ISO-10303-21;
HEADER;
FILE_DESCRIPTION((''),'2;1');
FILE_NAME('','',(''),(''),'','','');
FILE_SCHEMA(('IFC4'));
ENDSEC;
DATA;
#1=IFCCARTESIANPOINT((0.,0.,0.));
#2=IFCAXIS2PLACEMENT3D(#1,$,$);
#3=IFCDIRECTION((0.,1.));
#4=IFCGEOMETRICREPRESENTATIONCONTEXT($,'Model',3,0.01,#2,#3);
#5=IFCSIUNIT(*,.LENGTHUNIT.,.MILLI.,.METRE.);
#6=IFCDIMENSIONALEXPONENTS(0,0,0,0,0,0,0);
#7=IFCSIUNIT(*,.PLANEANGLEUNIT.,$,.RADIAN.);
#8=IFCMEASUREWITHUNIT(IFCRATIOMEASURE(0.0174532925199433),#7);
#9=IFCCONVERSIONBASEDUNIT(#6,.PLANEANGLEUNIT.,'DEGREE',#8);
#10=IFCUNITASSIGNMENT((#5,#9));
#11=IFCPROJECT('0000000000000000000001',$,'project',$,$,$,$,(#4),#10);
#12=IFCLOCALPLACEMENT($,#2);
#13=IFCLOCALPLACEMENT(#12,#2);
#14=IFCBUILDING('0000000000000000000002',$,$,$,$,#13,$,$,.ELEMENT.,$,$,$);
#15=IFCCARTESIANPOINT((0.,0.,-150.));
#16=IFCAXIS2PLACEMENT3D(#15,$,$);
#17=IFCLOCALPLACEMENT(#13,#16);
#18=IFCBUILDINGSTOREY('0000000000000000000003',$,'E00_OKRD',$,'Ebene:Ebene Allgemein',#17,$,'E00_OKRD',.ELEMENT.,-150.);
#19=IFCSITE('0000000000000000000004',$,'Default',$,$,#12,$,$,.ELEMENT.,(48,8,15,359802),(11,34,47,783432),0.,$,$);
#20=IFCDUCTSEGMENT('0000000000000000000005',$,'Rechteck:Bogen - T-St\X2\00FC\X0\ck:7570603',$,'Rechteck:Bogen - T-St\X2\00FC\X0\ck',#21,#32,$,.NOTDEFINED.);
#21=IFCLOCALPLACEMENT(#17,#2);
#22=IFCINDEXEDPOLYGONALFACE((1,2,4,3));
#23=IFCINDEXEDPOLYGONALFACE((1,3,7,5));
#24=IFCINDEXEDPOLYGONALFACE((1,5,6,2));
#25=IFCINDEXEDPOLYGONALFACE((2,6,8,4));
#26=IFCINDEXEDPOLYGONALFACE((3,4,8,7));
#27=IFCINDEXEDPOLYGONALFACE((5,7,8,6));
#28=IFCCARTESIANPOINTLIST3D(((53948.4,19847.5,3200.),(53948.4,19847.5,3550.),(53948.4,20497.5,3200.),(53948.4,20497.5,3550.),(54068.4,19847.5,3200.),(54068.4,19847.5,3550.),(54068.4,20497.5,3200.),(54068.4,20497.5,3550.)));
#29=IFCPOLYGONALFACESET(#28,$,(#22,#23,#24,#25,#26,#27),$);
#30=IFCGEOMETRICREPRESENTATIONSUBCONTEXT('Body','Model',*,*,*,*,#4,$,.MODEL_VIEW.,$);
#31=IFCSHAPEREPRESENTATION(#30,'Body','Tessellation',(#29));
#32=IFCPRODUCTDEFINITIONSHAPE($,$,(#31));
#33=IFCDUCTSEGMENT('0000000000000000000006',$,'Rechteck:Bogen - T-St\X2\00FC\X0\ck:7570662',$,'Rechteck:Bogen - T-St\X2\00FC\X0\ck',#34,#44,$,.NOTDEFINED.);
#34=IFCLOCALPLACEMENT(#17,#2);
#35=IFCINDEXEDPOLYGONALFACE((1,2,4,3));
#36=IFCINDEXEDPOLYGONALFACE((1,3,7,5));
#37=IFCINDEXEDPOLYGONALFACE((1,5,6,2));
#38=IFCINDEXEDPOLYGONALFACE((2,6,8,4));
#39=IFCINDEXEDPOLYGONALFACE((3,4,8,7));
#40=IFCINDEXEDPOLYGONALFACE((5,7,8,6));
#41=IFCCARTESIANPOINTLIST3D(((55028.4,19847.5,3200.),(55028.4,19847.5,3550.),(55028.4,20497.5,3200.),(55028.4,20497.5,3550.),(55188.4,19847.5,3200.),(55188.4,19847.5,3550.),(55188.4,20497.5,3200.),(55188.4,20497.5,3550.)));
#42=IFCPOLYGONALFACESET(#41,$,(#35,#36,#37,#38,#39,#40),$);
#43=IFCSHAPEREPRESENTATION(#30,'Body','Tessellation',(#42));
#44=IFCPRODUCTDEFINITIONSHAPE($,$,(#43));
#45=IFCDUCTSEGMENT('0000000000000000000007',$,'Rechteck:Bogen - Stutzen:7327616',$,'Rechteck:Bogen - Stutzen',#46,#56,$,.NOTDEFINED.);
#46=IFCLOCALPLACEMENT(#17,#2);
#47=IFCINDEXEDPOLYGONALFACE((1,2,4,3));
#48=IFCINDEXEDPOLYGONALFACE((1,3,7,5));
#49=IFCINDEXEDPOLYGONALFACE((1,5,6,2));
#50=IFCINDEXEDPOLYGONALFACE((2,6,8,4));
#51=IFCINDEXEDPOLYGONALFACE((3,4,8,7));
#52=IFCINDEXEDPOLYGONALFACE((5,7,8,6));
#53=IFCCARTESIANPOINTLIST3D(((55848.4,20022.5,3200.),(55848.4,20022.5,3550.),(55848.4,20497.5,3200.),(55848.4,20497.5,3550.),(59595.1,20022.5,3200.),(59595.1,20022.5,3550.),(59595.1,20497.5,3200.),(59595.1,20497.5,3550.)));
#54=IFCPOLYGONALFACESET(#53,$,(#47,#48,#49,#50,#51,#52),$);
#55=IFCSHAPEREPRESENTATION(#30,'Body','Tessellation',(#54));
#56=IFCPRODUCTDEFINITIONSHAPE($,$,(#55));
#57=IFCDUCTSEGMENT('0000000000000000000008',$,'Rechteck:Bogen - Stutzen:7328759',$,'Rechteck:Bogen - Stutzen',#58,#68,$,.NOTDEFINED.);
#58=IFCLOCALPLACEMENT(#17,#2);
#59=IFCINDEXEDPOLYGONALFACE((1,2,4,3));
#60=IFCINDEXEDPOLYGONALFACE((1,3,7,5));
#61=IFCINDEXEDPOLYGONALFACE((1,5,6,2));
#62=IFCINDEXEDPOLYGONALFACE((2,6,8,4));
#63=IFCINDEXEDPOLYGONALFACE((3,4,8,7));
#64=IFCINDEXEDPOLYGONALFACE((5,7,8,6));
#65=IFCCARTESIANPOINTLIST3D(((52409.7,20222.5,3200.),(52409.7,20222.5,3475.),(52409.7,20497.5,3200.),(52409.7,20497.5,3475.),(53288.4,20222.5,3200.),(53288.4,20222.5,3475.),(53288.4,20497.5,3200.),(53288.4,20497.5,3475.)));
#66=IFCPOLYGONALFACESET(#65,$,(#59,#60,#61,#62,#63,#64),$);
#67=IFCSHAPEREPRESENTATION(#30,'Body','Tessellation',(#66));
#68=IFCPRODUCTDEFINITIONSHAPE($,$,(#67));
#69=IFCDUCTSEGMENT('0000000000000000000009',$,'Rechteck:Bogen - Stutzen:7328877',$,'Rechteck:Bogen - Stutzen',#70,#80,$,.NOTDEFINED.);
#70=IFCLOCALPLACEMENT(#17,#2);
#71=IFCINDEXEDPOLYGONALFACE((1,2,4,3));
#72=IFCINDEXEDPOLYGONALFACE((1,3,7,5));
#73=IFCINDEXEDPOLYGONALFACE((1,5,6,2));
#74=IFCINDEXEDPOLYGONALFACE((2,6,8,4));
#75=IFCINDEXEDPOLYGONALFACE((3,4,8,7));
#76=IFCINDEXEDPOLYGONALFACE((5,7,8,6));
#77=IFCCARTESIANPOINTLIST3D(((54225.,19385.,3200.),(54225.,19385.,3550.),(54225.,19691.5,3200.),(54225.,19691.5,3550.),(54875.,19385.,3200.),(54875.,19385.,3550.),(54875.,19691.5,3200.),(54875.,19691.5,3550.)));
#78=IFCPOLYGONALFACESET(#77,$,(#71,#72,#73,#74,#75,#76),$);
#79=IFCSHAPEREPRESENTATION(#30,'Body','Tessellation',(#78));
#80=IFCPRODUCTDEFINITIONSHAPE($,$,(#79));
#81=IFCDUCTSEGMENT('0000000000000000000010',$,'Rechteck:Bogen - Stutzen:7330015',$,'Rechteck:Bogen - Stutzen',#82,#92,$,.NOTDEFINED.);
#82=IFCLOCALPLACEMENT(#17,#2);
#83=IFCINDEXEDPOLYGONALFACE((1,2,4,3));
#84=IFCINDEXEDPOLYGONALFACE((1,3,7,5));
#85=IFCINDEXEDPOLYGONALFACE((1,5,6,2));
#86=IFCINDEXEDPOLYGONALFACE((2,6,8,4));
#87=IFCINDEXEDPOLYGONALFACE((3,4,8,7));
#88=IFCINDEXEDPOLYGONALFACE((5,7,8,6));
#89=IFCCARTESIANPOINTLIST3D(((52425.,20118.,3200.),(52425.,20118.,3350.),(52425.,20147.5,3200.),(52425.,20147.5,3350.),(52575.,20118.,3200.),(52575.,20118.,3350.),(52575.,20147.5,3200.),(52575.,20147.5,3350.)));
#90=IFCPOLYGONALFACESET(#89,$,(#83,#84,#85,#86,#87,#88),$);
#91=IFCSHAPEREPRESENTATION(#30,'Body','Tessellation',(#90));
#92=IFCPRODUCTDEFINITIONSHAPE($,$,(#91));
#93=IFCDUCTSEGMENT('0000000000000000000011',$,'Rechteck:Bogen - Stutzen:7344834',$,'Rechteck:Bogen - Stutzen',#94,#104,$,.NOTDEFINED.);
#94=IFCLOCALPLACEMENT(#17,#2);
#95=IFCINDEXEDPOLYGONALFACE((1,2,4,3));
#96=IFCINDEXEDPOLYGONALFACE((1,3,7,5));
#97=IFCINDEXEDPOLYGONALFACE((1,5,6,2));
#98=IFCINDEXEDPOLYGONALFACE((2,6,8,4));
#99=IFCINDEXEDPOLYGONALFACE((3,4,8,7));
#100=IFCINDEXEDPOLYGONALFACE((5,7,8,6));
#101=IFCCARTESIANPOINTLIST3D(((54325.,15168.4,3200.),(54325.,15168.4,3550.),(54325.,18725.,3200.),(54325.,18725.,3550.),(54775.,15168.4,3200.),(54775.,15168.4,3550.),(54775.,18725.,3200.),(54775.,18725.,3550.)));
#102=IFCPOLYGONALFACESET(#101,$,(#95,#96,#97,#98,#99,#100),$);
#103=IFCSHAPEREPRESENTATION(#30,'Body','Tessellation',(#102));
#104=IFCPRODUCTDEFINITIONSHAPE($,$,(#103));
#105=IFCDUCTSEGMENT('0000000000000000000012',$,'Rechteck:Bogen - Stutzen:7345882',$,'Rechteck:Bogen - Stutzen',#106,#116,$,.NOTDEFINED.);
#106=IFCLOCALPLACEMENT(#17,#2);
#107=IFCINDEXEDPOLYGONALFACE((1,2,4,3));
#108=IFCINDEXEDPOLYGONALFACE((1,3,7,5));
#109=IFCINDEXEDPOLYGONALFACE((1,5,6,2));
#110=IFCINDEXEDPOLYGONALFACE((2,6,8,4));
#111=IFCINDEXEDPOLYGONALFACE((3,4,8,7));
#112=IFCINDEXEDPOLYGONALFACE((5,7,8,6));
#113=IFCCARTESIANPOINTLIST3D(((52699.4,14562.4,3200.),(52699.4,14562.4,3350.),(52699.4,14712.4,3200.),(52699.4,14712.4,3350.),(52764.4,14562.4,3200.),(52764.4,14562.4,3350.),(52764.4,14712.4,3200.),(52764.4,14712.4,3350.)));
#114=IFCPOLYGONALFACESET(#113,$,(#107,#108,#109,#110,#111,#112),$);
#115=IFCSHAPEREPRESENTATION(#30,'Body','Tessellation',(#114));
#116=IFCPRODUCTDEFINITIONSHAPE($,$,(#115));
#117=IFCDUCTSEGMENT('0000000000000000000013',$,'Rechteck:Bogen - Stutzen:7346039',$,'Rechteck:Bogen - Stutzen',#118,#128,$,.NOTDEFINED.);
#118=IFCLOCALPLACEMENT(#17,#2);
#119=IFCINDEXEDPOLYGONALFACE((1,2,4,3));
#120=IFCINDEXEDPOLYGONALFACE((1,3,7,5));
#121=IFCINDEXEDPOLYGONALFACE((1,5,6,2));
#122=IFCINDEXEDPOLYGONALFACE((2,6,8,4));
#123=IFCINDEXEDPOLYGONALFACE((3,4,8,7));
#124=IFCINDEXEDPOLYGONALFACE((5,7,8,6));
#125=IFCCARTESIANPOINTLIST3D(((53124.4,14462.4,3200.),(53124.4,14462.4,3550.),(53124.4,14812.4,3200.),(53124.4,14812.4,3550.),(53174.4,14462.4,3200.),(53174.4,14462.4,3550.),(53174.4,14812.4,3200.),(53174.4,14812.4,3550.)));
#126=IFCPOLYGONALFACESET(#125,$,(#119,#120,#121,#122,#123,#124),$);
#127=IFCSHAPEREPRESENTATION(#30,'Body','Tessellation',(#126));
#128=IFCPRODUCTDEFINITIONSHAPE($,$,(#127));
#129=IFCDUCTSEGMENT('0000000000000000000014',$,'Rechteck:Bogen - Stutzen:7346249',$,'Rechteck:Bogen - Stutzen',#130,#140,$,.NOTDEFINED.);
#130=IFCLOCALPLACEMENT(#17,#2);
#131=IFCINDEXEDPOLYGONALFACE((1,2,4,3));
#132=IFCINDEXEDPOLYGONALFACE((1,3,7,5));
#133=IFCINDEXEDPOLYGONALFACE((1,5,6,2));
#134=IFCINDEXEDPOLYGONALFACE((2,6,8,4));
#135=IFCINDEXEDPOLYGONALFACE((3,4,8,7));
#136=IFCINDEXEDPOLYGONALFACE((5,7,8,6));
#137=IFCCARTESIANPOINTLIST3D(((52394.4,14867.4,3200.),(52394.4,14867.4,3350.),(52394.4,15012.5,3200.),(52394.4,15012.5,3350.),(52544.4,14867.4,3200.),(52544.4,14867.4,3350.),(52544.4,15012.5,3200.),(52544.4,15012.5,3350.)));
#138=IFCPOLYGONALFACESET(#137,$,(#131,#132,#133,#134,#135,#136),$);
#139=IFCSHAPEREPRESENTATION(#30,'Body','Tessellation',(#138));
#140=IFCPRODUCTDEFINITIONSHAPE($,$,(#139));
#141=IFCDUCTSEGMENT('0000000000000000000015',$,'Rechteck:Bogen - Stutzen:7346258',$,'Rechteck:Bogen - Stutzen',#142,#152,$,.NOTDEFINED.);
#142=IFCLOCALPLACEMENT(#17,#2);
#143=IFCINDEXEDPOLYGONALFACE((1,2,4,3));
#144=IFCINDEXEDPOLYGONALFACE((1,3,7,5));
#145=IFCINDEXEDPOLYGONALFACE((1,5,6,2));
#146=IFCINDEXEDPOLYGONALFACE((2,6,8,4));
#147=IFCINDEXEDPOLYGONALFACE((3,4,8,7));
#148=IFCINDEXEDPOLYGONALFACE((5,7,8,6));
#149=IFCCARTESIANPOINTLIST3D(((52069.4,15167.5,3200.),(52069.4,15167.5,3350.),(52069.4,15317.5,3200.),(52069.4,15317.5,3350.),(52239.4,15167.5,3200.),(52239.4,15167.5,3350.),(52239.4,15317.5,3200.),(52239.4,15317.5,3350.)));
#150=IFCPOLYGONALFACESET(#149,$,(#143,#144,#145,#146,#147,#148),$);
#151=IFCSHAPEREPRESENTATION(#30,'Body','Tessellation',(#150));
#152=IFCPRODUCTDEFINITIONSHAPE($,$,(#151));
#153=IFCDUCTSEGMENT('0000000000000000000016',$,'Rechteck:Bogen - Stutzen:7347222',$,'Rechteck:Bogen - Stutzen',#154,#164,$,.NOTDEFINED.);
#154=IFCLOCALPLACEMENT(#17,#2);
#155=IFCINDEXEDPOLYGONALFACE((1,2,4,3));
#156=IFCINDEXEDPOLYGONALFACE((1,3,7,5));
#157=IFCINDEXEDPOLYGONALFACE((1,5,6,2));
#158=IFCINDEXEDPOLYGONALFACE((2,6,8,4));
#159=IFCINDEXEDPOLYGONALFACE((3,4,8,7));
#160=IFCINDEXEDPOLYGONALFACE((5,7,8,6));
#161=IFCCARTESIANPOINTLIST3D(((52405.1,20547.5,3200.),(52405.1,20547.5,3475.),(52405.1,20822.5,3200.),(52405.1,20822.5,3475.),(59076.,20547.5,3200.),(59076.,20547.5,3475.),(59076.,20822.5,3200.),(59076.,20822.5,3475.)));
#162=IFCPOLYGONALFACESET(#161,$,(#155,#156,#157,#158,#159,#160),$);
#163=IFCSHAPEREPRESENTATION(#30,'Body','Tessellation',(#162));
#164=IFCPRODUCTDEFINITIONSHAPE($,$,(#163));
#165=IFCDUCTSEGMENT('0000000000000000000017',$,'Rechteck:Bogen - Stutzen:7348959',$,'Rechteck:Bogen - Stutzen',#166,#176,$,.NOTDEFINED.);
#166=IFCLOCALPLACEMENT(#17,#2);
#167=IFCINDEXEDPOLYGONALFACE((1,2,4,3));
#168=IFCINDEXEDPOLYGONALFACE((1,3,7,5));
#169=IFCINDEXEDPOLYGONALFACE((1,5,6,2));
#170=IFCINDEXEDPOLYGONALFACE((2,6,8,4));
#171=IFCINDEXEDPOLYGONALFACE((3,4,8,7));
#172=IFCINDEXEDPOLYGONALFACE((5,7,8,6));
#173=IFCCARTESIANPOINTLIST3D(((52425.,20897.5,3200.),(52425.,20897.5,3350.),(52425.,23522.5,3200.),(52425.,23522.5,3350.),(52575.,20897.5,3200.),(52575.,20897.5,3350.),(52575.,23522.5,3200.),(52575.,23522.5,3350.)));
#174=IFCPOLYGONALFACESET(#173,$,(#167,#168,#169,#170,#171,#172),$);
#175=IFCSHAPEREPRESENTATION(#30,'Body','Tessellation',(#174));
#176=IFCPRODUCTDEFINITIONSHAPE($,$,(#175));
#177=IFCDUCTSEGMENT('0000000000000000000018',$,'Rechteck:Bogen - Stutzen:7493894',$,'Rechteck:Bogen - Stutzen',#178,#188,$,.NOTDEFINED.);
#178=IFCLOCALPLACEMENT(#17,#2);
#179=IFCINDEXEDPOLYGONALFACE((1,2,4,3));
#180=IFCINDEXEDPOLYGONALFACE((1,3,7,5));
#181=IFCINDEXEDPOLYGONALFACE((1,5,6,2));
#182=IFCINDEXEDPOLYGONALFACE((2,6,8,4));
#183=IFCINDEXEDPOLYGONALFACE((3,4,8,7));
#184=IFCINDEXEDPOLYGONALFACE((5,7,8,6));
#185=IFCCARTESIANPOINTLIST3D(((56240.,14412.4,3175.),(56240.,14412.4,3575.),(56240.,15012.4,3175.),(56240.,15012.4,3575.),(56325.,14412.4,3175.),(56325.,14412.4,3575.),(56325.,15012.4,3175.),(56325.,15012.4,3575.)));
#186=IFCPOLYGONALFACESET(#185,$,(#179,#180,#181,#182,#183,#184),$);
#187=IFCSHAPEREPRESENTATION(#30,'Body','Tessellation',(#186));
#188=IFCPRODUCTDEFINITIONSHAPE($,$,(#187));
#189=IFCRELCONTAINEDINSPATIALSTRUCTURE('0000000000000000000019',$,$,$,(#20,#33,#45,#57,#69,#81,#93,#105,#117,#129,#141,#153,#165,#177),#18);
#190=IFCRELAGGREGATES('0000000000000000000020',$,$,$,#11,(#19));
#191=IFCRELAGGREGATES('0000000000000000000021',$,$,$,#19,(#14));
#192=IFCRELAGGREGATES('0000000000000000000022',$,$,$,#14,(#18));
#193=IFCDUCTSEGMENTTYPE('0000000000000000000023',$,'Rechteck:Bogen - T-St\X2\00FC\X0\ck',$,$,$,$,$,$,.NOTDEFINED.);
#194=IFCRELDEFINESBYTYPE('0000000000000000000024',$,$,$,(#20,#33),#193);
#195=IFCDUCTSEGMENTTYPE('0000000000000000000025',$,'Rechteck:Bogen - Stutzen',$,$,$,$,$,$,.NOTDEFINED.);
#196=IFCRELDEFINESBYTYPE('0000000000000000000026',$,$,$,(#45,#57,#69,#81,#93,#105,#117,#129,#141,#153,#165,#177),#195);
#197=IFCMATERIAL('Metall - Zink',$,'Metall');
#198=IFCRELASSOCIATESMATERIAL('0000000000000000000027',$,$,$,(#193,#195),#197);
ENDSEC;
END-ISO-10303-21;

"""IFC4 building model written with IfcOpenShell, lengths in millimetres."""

from ifc_helpers import new_model, entity, si_unit, converted_unit, direction, frame, frame_2d, origin, origin_2d_with_axis, place, context, subcontext, project, spatial, rectangle, extrude, material, type_object, element, save


model = new_model("IFC4")

# Units and contexts
model_context = context("Model", 3, precision=0.01, world=origin(), true_north=direction((0.0, 1.0)))
body_context = subcontext(model_context, "Body", "Model", "MODEL_VIEW")
ifc_project = project(units=[si_unit("LENGTHUNIT", "METRE", prefix="MILLI"), converted_unit("PLANEANGLEUNIT", "DEGREE", entity("IfcRatioMeasure", 0.0174532925199433), si_unit("PLANEANGLEUNIT", "RADIAN"), dimensions=[0, 0, 0, 0, 0, 0, 0])], contexts=[model_context])

# Site, building, storey
site_placement = place(None, origin())
site = spatial("IfcSite", under=ifc_project, at=site_placement, Name="Default", CompositionType="ELEMENT", RefLatitude=(48, 8, 15, 359802), RefLongitude=(11, 34, 47, 783432), RefElevation=0.0)
building_placement = place(site_placement, origin())
building = spatial("IfcBuilding", under=site, at=building_placement, CompositionType="ELEMENT")
storey_placement = place(building_placement, frame((0.0, 0.0, -150.0)))
storey = spatial("IfcBuildingStorey", under=building, at=storey_placement, Name="E00_OKRD", ObjectType="Ebene:Ebene Allgemein", LongName="E00_OKRD", CompositionType="ELEMENT", Elevation=-150.0)

# Duct segments
ifc_material_1 = material(Name="Metall - Zink", Category="Metall")
duct_segment_type_1 = type_object("IfcDuctSegmentType", Name="Rechteck:Bogen - T-Stück", PredefinedType="NOTDEFINED", material=ifc_material_1)
duct_segment_1_placement = place(storey_placement, frame((53948.4, 19847.5, 3200.0)))
element("IfcDuctSegment", 1, at=duct_segment_1_placement, inside=storey, type_object=duct_segment_type_1, Name="Rechteck:Bogen - T-Stück:7570603", ObjectType="Rechteck:Bogen - T-Stück", PredefinedType="NOTDEFINED", context=body_context, shape_type="SweptSolid", body=[
    extrude(rectangle(XDim=120.0, YDim=650.0, at=frame_2d((0.0, 0.0), x_axis=(1.0, 0.0))), frame((60.0, 325.0, 0.0), z_axis=(0.0, 0.0, 1.0), x_axis=(-1.0, 0.0, 0.0)), (0.0, 0.0, 1.0), 350.0),
])
duct_segment_2_placement = place(storey_placement, frame((55028.4, 19847.5, 3200.0)))
element("IfcDuctSegment", 2, at=duct_segment_2_placement, inside=storey, type_object=duct_segment_type_1, Name="Rechteck:Bogen - T-Stück:7570662", ObjectType="Rechteck:Bogen - T-Stück", PredefinedType="NOTDEFINED", context=body_context, shape_type="SweptSolid", body=[
    extrude(rectangle(XDim=160.0, YDim=650.0, at=origin_2d_with_axis()), frame((80.0, 325.0, 0.0), z_axis=(0.0, 0.0, 1.0), x_axis=(-1.0, 0.0, 0.0)), (0.0, 0.0, 1.0), 350.0),
])
duct_segment_type_2 = type_object("IfcDuctSegmentType", Name="Rechteck:Bogen - Stutzen", PredefinedType="NOTDEFINED", material=ifc_material_1)
duct_segment_3_placement = place(storey_placement, frame((55848.4, 20022.5, 3200.0)))
element("IfcDuctSegment", 3, at=duct_segment_3_placement, inside=storey, type_object=duct_segment_type_2, Name="Rechteck:Bogen - Stutzen:7327616", ObjectType="Rechteck:Bogen - Stutzen", PredefinedType="NOTDEFINED", context=body_context, shape_type="SweptSolid", body=[
    extrude(rectangle(XDim=3746.8, YDim=475.0, at=origin_2d_with_axis()), frame((1873.4, 237.5, 0.0), z_axis=(0.0, 0.0, 1.0), x_axis=(-1.0, 0.0, 0.0)), (0.0, 0.0, 1.0), 350.0),
])
duct_segment_4_placement = place(storey_placement, frame((52409.7, 20222.5, 3200.0)))
element("IfcDuctSegment", 4, at=duct_segment_4_placement, inside=storey, type_object=duct_segment_type_2, Name="Rechteck:Bogen - Stutzen:7328759", ObjectType="Rechteck:Bogen - Stutzen", PredefinedType="NOTDEFINED", context=body_context, shape_type="SweptSolid", body=[
    extrude(rectangle(XDim=878.6, YDim=275.0, at=frame_2d((0.0, 0.0), x_axis=(1.0, 0.0))), frame((439.3, 137.5, 0.0), z_axis=(0.0, 0.0, 1.0), x_axis=(-1.0, 0.0, 0.0)), (0.0, 0.0, 1.0), 275.0),
])
duct_segment_5_placement = place(storey_placement, frame((54225.0, 19385.0, 3200.0)))
element("IfcDuctSegment", 5, at=duct_segment_5_placement, inside=storey, type_object=duct_segment_type_2, Name="Rechteck:Bogen - Stutzen:7328877", ObjectType="Rechteck:Bogen - Stutzen", PredefinedType="NOTDEFINED", context=body_context, shape_type="SweptSolid", body=[
    extrude(rectangle(XDim=306.5, YDim=650.0, at=frame_2d((0.0, 0.0), x_axis=(1.0, 0.0))), frame((325.0, 153.2, 0.0), z_axis=(0.0, 0.0, 1.0), x_axis=(0.0, -1.0, 0.0)), (0.0, 0.0, 1.0), 350.0),
])
duct_segment_6_placement = place(storey_placement, frame((52425.0, 20118.0, 3200.0)))
element("IfcDuctSegment", 6, at=duct_segment_6_placement, inside=storey, type_object=duct_segment_type_2, Name="Rechteck:Bogen - Stutzen:7330015", ObjectType="Rechteck:Bogen - Stutzen", PredefinedType="NOTDEFINED", context=body_context, shape_type="SweptSolid", body=[
    extrude(rectangle(XDim=29.5, YDim=150.0, at=frame_2d((0.0, 0.0), x_axis=(1.0, 0.0))), frame((75.0, 14.7, 0.0), z_axis=(0.0, 0.0, 1.0), x_axis=(0.0, -1.0, 0.0)), (0.0, 0.0, 1.0), 150.0),
])
duct_segment_7_placement = place(storey_placement, frame((54325.0, 15168.4, 3200.0)))
element("IfcDuctSegment", 7, at=duct_segment_7_placement, inside=storey, type_object=duct_segment_type_2, Name="Rechteck:Bogen - Stutzen:7344834", ObjectType="Rechteck:Bogen - Stutzen", PredefinedType="NOTDEFINED", context=body_context, shape_type="SweptSolid", body=[
    extrude(rectangle(XDim=3556.5, YDim=450.0, at=frame_2d((0.0, 0.0), x_axis=(1.0, 0.0))), frame((225.0, 1778.3, 0.0), z_axis=(0.0, 0.0, 1.0), x_axis=(0.0, 1.0, 0.0)), (0.0, 0.0, 1.0), 350.0),
])
duct_segment_8_placement = place(storey_placement, frame((52699.4, 14562.4, 3200.0)))
element("IfcDuctSegment", 8, at=duct_segment_8_placement, inside=storey, type_object=duct_segment_type_2, Name="Rechteck:Bogen - Stutzen:7345882", ObjectType="Rechteck:Bogen - Stutzen", PredefinedType="NOTDEFINED", context=body_context, shape_type="SweptSolid", body=[
    extrude(rectangle(XDim=65.0, YDim=150.0, at=origin_2d_with_axis()), frame((32.5, 75.0, 0.0), z_axis=(0.0, 0.0, 1.0), x_axis=(-1.0, 0.0, 0.0)), (0.0, 0.0, 1.0), 150.0),
])
duct_segment_9_placement = place(storey_placement, frame((53124.4, 14462.4, 3200.0)))
element("IfcDuctSegment", 9, at=duct_segment_9_placement, inside=storey, type_object=duct_segment_type_2, Name="Rechteck:Bogen - Stutzen:7346039", ObjectType="Rechteck:Bogen - Stutzen", PredefinedType="NOTDEFINED", context=body_context, shape_type="SweptSolid", body=[
    extrude(rectangle(XDim=50.0, YDim=350.0, at=frame_2d((0.0, 0.0), x_axis=(1.0, 0.0))), frame((25.0, 175.0, 0.0), z_axis=(0.0, 0.0, 1.0), x_axis=(-1.0, 0.0, 0.0)), (0.0, 0.0, 1.0), 350.0),
])
duct_segment_10_placement = place(storey_placement, frame((52394.4, 14867.4, 3200.0)))
element("IfcDuctSegment", 10, at=duct_segment_10_placement, inside=storey, type_object=duct_segment_type_2, Name="Rechteck:Bogen - Stutzen:7346249", ObjectType="Rechteck:Bogen - Stutzen", PredefinedType="NOTDEFINED", context=body_context, shape_type="SweptSolid", body=[
    extrude(rectangle(XDim=145.1, YDim=150.0, at=frame_2d((0.0, 0.0), x_axis=(1.0, 0.0))), frame((75.0, 72.5, 0.0), z_axis=(0.0, 0.000177, 1.0), x_axis=(0.0, 1.0, -0.000177)), (0.0, 0.0, 1.0), 150.0),
])
duct_segment_11_placement = place(storey_placement, frame((52069.4, 15167.5, 3200.0)))
element("IfcDuctSegment", 11, at=duct_segment_11_placement, inside=storey, type_object=duct_segment_type_2, Name="Rechteck:Bogen - Stutzen:7346258", ObjectType="Rechteck:Bogen - Stutzen", PredefinedType="NOTDEFINED", context=body_context, shape_type="SweptSolid", body=[
    extrude(rectangle(XDim=170.0, YDim=150.0, at=frame_2d((0.0, 0.0), x_axis=(1.0, 0.0))), frame((85.0, 75.0, 0.0), z_axis=(0.0, 0.0, 1.0), x_axis=(-1.0, 0.0, 0.0)), (0.0, 0.0, 1.0), 150.0),
])
duct_segment_12_placement = place(storey_placement, frame((52405.1, 20547.5, 3200.0)))
element("IfcDuctSegment", 12, at=duct_segment_12_placement, inside=storey, type_object=duct_segment_type_2, Name="Rechteck:Bogen - Stutzen:7347222", ObjectType="Rechteck:Bogen - Stutzen", PredefinedType="NOTDEFINED", context=body_context, shape_type="SweptSolid", body=[
    extrude(rectangle(XDim=6670.8, YDim=275.0, at=origin_2d_with_axis()), frame((3335.4, 137.5, 0.0), z_axis=(0.0, 0.0, 1.0), x_axis=(-1.0, 0.0, 0.0)), (0.0, 0.0, 1.0), 275.0),
])
duct_segment_13_placement = place(storey_placement, frame((52425.0, 20897.5, 3200.0)))
element("IfcDuctSegment", 13, at=duct_segment_13_placement, inside=storey, type_object=duct_segment_type_2, Name="Rechteck:Bogen - Stutzen:7348959", ObjectType="Rechteck:Bogen - Stutzen", PredefinedType="NOTDEFINED", context=body_context, shape_type="SweptSolid", body=[
    extrude(rectangle(XDim=2625.0, YDim=150.0, at=frame_2d((0.0, 0.0), x_axis=(1.0, 0.0))), frame((75.0, 1312.5, 0.0), z_axis=(0.0, 0.0, 1.0), x_axis=(0.0, 1.0, 0.0)), (0.0, 0.0, 1.0), 150.0),
])
duct_segment_14_placement = place(storey_placement, frame((56240.0, 14412.4, 3175.0)))
element("IfcDuctSegment", 14, at=duct_segment_14_placement, inside=storey, type_object=duct_segment_type_2, Name="Rechteck:Bogen - Stutzen:7493894", ObjectType="Rechteck:Bogen - Stutzen", PredefinedType="NOTDEFINED", context=body_context, shape_type="SweptSolid", body=[
    extrude(rectangle(XDim=85.0, YDim=600.0, at=origin_2d_with_axis()), frame((42.5, 300.0, 0.0), z_axis=(0.0, 0.0, 1.0), x_axis=(-1.0, 0.0, 0.0)), (0.0, 0.0, 1.0), 400.0),
])

save(model, "model.ifc")
